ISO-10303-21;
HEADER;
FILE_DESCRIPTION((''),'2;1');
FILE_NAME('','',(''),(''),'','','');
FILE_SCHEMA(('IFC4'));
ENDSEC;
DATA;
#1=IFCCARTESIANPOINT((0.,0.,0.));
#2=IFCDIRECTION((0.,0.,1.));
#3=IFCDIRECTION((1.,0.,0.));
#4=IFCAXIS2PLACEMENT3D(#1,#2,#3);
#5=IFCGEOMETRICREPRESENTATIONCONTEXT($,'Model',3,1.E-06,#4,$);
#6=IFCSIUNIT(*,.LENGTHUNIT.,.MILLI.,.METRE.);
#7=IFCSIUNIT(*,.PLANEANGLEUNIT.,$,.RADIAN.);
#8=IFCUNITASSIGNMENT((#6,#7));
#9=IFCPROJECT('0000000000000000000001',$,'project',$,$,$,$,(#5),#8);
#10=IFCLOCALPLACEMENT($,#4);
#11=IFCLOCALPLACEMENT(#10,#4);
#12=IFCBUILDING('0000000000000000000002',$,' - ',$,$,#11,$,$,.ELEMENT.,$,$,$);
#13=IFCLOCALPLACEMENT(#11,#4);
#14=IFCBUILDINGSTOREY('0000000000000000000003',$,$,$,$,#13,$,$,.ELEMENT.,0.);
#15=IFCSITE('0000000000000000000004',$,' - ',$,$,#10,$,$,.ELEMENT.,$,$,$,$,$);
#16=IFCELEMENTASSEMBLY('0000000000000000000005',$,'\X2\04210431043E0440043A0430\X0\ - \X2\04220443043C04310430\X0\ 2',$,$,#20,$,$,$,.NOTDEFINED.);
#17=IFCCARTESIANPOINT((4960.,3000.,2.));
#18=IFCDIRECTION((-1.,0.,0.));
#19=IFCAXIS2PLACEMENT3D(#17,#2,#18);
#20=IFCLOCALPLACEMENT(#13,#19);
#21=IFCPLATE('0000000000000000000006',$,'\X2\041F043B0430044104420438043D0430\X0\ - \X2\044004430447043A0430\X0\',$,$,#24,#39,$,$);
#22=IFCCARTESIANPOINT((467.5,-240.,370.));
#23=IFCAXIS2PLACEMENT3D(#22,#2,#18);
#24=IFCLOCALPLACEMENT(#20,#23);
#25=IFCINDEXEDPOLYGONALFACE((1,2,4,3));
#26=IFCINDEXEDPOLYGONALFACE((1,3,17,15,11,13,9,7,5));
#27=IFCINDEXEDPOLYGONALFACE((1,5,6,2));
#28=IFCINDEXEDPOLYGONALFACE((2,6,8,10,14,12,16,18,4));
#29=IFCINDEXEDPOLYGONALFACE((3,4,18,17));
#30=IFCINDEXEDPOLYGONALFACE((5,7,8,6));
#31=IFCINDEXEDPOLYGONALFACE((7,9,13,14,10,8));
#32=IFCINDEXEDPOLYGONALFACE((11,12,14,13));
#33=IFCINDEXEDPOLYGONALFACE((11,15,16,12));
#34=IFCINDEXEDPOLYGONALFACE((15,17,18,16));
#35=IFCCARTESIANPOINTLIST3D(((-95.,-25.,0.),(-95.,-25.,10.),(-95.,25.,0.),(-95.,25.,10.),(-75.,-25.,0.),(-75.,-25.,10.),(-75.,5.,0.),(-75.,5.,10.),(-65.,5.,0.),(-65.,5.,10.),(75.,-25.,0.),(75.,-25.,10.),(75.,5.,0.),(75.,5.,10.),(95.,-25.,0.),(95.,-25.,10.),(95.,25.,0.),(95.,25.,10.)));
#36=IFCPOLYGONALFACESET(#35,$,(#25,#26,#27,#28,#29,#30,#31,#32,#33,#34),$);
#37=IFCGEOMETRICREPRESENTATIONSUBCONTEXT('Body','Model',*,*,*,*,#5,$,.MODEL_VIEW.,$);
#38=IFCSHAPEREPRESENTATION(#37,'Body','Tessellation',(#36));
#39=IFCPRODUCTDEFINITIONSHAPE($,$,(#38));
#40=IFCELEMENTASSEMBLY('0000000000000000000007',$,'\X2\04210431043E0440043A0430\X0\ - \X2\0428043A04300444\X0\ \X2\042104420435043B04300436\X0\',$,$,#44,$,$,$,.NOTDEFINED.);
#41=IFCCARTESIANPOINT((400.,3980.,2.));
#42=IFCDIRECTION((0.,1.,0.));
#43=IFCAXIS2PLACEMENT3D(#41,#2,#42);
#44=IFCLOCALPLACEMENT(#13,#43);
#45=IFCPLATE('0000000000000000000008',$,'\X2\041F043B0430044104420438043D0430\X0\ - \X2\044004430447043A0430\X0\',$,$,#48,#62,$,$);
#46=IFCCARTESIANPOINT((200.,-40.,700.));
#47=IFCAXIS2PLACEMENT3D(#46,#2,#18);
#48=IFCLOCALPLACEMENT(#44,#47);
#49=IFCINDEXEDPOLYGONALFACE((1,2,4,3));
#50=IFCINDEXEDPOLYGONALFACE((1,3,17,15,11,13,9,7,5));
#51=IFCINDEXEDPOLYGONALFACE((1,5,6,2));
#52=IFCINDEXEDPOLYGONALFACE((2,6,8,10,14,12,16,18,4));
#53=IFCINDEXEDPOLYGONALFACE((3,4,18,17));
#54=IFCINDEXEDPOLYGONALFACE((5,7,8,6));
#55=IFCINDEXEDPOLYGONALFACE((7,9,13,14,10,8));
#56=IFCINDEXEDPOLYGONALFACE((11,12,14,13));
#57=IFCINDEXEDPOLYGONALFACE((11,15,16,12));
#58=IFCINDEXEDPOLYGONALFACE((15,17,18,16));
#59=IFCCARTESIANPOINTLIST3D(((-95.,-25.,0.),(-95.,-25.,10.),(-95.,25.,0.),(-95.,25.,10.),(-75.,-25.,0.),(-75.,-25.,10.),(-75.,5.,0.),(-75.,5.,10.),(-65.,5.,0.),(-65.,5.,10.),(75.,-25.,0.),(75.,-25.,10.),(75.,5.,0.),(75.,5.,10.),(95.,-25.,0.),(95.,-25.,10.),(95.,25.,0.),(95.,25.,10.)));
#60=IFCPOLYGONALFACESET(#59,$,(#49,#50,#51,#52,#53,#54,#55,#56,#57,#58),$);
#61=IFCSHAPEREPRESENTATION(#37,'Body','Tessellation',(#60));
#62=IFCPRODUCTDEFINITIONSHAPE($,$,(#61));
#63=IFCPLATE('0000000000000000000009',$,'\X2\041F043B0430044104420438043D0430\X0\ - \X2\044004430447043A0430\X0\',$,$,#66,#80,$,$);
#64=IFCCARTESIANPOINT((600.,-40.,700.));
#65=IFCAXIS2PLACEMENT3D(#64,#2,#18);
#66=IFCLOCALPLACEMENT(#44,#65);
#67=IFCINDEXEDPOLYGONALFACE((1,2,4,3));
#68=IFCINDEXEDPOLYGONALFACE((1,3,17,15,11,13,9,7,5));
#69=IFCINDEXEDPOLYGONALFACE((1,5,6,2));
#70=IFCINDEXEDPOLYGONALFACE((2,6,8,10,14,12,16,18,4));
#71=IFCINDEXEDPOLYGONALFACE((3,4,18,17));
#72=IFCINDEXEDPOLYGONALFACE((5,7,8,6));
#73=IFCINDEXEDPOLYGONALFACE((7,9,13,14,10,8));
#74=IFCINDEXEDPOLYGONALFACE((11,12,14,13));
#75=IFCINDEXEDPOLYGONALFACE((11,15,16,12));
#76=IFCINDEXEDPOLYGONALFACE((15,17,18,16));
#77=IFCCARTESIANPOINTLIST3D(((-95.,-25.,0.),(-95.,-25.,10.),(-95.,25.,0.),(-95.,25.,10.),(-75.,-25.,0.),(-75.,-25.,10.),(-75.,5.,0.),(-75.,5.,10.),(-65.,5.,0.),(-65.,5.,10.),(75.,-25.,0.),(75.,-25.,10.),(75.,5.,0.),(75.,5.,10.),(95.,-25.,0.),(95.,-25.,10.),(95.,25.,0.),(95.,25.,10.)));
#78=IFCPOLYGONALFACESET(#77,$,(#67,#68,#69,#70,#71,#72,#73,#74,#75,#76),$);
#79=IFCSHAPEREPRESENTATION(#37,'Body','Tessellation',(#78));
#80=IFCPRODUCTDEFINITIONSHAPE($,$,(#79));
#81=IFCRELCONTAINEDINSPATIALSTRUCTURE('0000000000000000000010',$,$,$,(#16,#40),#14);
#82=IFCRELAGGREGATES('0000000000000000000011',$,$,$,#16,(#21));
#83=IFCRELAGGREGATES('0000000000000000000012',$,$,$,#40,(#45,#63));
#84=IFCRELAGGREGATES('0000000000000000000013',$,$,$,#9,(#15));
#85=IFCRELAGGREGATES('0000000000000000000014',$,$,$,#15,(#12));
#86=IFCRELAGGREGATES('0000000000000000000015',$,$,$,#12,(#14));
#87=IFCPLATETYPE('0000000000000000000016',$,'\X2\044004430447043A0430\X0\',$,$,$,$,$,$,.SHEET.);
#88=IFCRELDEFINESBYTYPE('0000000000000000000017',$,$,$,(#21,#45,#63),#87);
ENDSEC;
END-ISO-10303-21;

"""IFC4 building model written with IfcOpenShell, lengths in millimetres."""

from ifc_helpers import new_model, si_unit, frame, origin_with_axes, place, context, subcontext, project, spatial, line, indexed_curve, outline, extrude, source, transform, mapped, type_object, element, aggregate, save


model = new_model("IFC4")

# Units and contexts
model_context = context("Model", 3, precision=1e-06, world=origin_with_axes())
body_context = subcontext(model_context, "Body", "Model", "MODEL_VIEW")
ifc_project = project(units=[si_unit("LENGTHUNIT", "METRE", prefix="MILLI"), si_unit("PLANEANGLEUNIT", "RADIAN")], contexts=[model_context])

# Site, building, storey
site_placement = place(None, origin_with_axes())
site = spatial("IfcSite", under=ifc_project, at=site_placement, Name=" - ", CompositionType="ELEMENT")
building_placement = place(site_placement, origin_with_axes())
building = spatial("IfcBuilding", under=site, at=building_placement, Name=" - ", CompositionType="ELEMENT")
storey_placement = place(building_placement, origin_with_axes())
storey = spatial("IfcBuildingStorey", under=building, at=storey_placement, CompositionType="ELEMENT", Elevation=0.0)

# Element assemblies, plates
assembly_1_placement = place(storey_placement, frame((4960.0, 3000.0, 2.0), z_axis=(0.0, 0.0, 1.0), x_axis=(-1.0, 0.0, 0.0)))
assembly_1 = element("IfcElementAssembly", 1, at=assembly_1_placement, inside=storey, Name="Сборка - Тумба 2", PredefinedType="NOTDEFINED")
plate_type = type_object("IfcPlateType", Name="ручка", PredefinedType="SHEET")
shared_shape_1 = source(origin_with_axes(), body_context, "Body", "SweptSolid", [
    extrude(outline(indexed_curve([(-95.0, -25.0), (-75.0, -25.0), (-75.0, 5.0), (-65.0, 5.0), (75.0, 5.0), (75.0, -25.0), (95.0, -25.0), (95.0, 25.0), (-95.0, 25.0)], segments=[line(1, 2), line(2, 3), line(3, 4), line(4, 5), line(5, 6), line(6, 7), line(7, 8), line(8, 9), line(9, 1)])), origin_with_axes(), (0.0, 0.0, 1.0), 10.0),
])
plate_1_placement = place(assembly_1_placement, frame((467.5, -240.0, 370.0), z_axis=(0.0, 0.0, 1.0), x_axis=(-1.0, 0.0, 0.0)))
plate_1 = element("IfcPlate", 2, at=plate_1_placement, type_object=plate_type, Name="Пластина - ручка", context=body_context, shape_type="MappedRepresentation", body=[
    mapped(shared_shape_1, transform((0.0, 0.0, 0.0), x_axis=(1.0, 0.0, 0.0), y_axis=(0.0, 1.0, 0.0), z_axis=(0.0, 0.0, 1.0), scale=1.0)),
])
aggregate(assembly_1, [plate_1])
assembly_2_placement = place(storey_placement, frame((400.0, 3980.0, 2.0), z_axis=(0.0, 0.0, 1.0), x_axis=(0.0, 1.0, 0.0)))
assembly_2 = element("IfcElementAssembly", 3, at=assembly_2_placement, inside=storey, Name="Сборка - Шкаф Стелаж", PredefinedType="NOTDEFINED")
plate_2_placement = place(assembly_2_placement, frame((200.0, -40.0, 700.0), z_axis=(0.0, 0.0, 1.0), x_axis=(-1.0, 0.0, 0.0)))
plate_2 = element("IfcPlate", 4, at=plate_2_placement, type_object=plate_type, Name="Пластина - ручка", context=body_context, shape_type="MappedRepresentation", body=[
    mapped(shared_shape_1, transform((0.0, 0.0, 0.0), x_axis=(1.0, 0.0, 0.0), y_axis=(0.0, 1.0, 0.0), z_axis=(0.0, 0.0, 1.0), scale=1.0)),
])
plate_3_placement = place(assembly_2_placement, frame((600.0, -40.0, 700.0), z_axis=(0.0, 0.0, 1.0), x_axis=(-1.0, 0.0, 0.0)))
plate_3 = element("IfcPlate", 5, at=plate_3_placement, type_object=plate_type, Name="Пластина - ручка", context=body_context, shape_type="MappedRepresentation", body=[
    mapped(shared_shape_1, transform((0.0, 0.0, 0.0), x_axis=(1.0, 0.0, 0.0), y_axis=(0.0, 1.0, 0.0), z_axis=(0.0, 0.0, 1.0), scale=1.0)),
])
aggregate(assembly_2, [plate_2, plate_3])

save(model, "model.ifc")
